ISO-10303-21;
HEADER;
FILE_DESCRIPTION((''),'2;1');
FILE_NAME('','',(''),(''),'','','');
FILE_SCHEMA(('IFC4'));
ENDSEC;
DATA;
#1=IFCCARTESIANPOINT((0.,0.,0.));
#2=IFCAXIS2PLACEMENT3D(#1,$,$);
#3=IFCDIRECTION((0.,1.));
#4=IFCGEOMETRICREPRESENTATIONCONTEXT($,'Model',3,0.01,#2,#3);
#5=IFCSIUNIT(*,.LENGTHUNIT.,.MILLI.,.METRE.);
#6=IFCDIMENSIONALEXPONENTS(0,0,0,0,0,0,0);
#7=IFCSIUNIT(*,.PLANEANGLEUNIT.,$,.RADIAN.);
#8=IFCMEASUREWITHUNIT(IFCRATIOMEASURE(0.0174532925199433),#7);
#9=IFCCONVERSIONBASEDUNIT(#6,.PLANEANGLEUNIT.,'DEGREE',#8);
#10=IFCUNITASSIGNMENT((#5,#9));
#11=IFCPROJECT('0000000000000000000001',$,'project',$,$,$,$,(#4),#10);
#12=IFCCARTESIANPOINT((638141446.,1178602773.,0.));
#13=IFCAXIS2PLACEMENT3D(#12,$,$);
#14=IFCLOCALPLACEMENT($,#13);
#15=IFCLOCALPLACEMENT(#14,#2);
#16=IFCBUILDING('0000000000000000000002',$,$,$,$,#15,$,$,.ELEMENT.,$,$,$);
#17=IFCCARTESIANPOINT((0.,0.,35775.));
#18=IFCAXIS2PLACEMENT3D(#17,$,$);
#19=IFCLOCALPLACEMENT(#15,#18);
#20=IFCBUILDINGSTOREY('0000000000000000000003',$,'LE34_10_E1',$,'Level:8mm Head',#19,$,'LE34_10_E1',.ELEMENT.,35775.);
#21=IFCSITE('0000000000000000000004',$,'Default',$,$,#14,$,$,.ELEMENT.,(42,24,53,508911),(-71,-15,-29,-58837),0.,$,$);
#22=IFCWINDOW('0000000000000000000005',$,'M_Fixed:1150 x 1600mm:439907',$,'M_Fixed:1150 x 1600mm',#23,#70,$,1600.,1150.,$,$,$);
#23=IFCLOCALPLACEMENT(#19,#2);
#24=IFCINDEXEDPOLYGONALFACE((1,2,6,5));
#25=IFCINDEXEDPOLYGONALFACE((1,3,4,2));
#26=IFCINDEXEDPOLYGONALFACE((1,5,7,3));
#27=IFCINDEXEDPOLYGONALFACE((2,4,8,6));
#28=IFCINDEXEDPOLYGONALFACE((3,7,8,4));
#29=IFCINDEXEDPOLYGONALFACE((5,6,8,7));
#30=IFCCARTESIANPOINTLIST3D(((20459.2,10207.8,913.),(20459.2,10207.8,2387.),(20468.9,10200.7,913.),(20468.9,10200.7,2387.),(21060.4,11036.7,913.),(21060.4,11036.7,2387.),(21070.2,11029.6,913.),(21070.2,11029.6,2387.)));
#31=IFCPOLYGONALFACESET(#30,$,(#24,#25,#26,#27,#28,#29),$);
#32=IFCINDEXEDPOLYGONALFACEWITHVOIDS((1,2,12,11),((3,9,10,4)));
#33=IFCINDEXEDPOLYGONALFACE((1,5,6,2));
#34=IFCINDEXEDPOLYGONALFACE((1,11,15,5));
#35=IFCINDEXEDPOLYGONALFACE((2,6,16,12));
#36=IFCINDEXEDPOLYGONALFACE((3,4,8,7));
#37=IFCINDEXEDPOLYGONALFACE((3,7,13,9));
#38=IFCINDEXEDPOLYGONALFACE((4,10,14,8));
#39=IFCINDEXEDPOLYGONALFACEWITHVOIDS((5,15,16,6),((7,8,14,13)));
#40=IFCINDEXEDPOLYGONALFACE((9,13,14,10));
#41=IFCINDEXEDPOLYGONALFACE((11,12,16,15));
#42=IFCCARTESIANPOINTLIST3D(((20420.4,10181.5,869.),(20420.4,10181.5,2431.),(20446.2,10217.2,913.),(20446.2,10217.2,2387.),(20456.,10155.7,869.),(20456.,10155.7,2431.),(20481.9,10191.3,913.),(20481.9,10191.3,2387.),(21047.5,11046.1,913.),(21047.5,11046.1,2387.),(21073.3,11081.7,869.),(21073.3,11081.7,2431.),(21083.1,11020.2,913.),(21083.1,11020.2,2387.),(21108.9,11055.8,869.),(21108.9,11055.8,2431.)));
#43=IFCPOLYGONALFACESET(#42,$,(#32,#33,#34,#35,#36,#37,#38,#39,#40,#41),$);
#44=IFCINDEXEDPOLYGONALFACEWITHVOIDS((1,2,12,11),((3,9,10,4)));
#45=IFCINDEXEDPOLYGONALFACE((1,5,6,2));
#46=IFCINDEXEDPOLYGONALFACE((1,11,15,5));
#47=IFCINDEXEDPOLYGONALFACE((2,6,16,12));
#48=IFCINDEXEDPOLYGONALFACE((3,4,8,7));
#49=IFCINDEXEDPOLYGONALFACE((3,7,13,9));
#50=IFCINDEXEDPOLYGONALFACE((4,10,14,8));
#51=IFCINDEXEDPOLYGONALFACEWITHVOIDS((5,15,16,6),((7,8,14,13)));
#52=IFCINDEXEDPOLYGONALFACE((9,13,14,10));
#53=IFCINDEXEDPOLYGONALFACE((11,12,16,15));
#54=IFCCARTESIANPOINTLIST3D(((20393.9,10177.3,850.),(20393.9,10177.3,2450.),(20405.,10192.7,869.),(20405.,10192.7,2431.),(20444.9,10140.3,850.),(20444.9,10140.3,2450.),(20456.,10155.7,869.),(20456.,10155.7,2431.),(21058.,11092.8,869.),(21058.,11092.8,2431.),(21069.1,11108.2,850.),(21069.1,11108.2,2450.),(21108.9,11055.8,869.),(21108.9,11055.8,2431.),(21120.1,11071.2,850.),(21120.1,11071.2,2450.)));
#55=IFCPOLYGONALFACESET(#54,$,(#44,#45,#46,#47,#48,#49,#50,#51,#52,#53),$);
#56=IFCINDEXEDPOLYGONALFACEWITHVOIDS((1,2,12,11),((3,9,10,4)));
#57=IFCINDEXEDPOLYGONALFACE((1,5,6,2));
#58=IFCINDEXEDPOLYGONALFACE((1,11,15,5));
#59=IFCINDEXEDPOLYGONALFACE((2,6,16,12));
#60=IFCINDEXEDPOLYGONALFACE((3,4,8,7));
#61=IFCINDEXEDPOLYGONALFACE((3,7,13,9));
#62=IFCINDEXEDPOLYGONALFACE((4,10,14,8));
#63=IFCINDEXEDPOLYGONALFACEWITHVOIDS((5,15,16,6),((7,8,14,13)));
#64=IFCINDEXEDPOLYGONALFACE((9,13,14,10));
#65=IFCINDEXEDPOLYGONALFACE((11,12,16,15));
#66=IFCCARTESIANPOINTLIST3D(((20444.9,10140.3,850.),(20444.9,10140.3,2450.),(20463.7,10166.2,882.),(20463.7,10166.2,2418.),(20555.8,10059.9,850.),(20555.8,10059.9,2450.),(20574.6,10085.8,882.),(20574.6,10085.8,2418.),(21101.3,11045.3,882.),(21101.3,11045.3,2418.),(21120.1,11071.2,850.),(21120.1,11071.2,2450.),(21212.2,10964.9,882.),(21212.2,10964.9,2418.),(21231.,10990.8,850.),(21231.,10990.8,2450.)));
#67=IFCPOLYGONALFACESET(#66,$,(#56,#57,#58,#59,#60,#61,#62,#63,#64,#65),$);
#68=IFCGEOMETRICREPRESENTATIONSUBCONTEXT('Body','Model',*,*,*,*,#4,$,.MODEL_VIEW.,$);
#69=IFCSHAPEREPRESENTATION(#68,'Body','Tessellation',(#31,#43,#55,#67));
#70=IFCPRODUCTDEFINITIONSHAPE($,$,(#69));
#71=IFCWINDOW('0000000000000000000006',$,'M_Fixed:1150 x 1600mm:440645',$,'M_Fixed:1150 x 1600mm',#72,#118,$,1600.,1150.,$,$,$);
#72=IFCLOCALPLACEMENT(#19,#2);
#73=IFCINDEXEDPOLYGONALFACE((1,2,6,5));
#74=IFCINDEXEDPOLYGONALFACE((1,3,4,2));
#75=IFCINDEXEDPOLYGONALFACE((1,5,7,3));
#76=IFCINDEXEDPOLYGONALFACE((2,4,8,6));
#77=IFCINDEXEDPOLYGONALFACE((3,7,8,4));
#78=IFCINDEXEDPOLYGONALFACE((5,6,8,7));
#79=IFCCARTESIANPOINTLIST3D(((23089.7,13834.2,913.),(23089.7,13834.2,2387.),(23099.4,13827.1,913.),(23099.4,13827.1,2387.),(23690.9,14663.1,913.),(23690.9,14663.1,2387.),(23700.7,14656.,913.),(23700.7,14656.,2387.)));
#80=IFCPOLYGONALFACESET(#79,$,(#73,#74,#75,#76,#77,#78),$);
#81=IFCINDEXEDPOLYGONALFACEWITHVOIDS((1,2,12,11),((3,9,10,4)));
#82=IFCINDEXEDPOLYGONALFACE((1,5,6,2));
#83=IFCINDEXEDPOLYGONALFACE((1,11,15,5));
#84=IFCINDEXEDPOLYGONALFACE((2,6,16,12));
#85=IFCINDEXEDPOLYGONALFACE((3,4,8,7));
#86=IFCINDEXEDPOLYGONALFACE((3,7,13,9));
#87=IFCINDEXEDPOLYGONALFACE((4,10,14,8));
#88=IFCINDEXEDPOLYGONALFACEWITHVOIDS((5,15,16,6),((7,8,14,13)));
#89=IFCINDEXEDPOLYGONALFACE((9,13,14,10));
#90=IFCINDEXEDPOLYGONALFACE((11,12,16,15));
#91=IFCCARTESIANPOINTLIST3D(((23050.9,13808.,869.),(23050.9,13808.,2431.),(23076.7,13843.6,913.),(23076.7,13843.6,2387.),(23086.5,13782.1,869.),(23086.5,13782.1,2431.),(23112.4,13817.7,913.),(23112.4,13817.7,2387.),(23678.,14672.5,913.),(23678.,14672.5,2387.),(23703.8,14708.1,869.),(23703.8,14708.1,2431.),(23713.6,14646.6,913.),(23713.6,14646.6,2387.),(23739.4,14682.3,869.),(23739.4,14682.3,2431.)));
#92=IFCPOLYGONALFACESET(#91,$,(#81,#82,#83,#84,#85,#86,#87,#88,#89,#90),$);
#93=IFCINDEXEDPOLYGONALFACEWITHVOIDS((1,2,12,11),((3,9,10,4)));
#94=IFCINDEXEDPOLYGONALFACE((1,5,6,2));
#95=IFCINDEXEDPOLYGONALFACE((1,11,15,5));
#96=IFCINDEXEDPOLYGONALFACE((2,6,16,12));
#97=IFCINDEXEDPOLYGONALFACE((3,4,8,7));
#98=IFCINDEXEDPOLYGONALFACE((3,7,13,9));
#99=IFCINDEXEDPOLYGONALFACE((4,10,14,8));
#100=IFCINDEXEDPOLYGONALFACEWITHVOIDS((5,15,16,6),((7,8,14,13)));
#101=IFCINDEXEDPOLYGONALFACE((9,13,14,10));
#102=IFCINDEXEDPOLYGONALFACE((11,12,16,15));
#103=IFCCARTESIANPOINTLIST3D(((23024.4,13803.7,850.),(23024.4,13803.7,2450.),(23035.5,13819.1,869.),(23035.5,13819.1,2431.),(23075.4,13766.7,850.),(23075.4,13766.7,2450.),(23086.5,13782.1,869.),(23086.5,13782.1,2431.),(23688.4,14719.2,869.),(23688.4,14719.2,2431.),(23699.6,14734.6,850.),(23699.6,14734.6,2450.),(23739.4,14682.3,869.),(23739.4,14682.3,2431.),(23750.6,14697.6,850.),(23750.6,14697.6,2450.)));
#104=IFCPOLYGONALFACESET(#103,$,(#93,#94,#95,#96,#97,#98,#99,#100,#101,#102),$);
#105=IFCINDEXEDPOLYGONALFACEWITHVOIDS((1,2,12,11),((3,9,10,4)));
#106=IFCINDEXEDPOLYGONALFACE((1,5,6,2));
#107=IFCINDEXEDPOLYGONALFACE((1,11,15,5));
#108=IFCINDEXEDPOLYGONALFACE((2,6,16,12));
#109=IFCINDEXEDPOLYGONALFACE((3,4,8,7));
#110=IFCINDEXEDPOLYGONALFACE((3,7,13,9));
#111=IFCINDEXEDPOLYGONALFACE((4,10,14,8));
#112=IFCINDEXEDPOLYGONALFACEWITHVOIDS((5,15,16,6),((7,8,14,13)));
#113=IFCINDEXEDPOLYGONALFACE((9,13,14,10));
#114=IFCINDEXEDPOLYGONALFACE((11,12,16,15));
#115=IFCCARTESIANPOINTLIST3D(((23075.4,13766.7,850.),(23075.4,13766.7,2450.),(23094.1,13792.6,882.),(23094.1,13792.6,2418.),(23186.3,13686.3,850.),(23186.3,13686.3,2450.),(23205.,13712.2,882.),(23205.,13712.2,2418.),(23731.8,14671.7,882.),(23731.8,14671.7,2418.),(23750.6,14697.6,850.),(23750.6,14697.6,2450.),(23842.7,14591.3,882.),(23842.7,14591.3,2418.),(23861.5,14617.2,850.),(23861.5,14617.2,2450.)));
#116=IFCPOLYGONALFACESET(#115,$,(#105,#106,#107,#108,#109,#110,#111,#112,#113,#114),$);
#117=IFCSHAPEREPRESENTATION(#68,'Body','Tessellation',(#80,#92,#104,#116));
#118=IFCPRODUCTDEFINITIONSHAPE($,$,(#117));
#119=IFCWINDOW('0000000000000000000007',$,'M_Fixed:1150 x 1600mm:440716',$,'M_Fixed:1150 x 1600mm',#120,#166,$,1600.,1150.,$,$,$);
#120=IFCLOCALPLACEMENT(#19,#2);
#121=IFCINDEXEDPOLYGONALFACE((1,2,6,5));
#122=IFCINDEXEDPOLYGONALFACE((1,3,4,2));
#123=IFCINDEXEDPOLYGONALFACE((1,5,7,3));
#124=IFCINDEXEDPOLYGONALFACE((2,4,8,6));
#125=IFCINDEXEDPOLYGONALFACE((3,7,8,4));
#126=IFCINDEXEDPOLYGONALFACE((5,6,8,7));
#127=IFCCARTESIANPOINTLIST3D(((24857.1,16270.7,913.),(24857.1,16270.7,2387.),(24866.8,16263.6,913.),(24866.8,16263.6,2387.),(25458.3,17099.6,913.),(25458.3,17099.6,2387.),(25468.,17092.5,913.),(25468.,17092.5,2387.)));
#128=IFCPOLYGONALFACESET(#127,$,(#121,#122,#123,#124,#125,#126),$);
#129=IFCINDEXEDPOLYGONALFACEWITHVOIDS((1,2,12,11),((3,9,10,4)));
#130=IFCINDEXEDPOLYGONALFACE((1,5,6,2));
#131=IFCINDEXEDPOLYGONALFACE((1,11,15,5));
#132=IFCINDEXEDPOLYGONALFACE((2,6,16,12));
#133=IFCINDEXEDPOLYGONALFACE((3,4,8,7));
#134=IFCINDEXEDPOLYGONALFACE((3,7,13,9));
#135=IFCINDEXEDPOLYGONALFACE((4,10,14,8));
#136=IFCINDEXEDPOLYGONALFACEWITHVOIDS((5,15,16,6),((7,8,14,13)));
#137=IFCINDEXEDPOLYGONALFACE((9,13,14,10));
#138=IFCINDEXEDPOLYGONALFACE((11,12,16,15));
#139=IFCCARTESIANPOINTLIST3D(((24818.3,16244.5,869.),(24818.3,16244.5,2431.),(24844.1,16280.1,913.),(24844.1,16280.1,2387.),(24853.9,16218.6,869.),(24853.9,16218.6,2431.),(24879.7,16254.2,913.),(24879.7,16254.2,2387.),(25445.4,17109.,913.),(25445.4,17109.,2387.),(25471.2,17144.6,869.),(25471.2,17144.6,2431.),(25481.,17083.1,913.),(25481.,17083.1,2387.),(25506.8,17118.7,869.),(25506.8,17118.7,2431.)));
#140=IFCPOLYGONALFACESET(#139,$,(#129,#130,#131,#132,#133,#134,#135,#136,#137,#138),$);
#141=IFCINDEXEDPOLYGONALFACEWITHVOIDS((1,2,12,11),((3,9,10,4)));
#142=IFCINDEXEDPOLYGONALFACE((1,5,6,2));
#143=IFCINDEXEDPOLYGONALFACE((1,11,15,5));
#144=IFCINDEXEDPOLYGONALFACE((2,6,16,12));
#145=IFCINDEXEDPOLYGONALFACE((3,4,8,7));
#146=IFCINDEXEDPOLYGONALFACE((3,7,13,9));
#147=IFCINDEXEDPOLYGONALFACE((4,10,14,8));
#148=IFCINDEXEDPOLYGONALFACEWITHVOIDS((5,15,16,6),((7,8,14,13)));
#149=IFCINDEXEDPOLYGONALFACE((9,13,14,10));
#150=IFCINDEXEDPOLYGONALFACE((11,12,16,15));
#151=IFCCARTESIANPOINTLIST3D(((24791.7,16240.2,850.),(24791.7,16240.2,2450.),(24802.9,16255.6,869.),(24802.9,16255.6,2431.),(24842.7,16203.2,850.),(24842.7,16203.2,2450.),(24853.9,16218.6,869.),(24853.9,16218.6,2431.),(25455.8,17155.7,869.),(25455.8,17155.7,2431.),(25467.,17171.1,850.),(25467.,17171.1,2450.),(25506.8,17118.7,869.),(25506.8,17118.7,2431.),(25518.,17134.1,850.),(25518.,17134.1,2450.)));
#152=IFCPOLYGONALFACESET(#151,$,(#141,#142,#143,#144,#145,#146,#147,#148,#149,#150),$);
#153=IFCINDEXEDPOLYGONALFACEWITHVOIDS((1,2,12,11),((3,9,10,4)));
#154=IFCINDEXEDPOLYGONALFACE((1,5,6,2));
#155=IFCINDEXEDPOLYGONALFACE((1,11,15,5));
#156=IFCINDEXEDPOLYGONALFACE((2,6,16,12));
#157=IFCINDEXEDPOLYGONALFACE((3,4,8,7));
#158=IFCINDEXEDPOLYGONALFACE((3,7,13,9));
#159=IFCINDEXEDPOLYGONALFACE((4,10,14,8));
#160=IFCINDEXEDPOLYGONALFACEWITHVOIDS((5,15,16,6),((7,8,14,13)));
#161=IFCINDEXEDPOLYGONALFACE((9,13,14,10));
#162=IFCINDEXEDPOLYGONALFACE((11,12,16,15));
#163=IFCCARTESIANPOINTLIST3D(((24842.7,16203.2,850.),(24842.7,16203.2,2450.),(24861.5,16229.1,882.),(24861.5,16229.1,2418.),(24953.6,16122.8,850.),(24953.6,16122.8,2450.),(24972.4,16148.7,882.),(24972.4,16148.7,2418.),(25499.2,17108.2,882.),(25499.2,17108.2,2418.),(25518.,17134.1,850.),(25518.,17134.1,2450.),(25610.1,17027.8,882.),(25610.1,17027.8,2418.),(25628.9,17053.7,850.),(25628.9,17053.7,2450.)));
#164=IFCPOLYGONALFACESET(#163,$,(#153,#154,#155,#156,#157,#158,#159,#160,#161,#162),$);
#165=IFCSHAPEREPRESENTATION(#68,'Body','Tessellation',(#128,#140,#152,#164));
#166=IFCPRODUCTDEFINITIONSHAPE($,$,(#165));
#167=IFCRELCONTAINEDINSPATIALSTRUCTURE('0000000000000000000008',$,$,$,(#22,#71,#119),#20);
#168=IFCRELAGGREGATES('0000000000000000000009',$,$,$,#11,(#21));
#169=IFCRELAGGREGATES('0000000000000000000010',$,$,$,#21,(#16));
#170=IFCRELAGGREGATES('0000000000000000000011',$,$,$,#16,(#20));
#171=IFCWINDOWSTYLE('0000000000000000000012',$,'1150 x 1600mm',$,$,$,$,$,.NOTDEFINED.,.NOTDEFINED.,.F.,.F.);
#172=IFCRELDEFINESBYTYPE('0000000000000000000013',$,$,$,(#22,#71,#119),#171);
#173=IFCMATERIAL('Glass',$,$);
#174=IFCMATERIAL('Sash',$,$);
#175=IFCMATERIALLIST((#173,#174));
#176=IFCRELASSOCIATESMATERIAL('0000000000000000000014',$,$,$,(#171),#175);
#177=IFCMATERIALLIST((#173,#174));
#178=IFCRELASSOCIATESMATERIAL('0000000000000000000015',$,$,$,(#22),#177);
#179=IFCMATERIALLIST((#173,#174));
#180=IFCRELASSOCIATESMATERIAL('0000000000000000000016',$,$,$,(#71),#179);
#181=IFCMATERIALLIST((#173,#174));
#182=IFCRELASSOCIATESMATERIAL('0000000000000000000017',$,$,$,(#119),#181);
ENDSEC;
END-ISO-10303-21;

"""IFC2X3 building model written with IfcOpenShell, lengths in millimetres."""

from ifc_helpers import new_model, entity, si_unit, converted_unit, direction, frame, frame_2d, origin, place, context, subcontext, project, spatial, polyline, rectangle, outline, extrude, source, transform, mapped, material, material_list, type_object, type_shapes, element, save


model = new_model("IFC2X3")

# Units and contexts
model_context = context("Model", 3, precision=0.01, world=origin(), true_north=direction((0.0, 1.0)))
body_context = subcontext(model_context, "Body", "Model", "MODEL_VIEW")
ifc_project = project(units=[si_unit("LENGTHUNIT", "METRE", prefix="MILLI"), converted_unit("PLANEANGLEUNIT", "DEGREE", entity("IfcRatioMeasure", 0.0174532925199433), si_unit("PLANEANGLEUNIT", "RADIAN"), dimensions=[0, 0, 0, 0, 0, 0, 0])], contexts=[model_context])

# Site, building, storey
site_placement = place(None, frame((638141446.0, 1178602773.0, 0.0)))
site = spatial("IfcSite", under=ifc_project, at=site_placement, Name="Default", CompositionType="ELEMENT", RefLatitude=(42, 24, 53, 508911), RefLongitude=(-71, -15, -29, -58837), RefElevation=0.0)
building_placement = place(site_placement, origin())
building = spatial("IfcBuilding", under=site, at=building_placement, CompositionType="ELEMENT")
storey_placement = place(building_placement, frame((0.0, 0.0, 35775.0)))
storey = spatial("IfcBuildingStorey", under=building, at=storey_placement, Name="LE34_10_E1", ObjectType="Level:8mm Head", LongName="LE34_10_E1", CompositionType="ELEMENT", Elevation=35775.0)

# Windows
ifc_material_1 = material(Name="Glass")
ifc_material_2 = material(Name="Sash")
ifc_material_list_1 = material_list([ifc_material_1, ifc_material_2])
ifc_material_list_2 = material_list([ifc_material_1, ifc_material_2])
window_style_1 = type_object("IfcWindowStyle", Name="1150 x 1600mm", ConstructionType="NOTDEFINED", OperationType="NOTDEFINED", ParameterTakesPrecedence=False, Sizeable=False, material=ifc_material_list_2)
shared_shape_1 = source(origin(), body_context, "Body", "SweptSolid", [
    extrude(rectangle(XDim=12.0, YDim=1024.0, at=frame_2d((0.0, 0.0), x_axis=(1.0, 0.0))), frame((575.0, 269.0, 63.0), z_axis=(0.0, 0.0, 1.0), x_axis=(0.0, -1.0, 0.0)), (0.0, 0.0, 1.0), 1474.0),
    extrude(outline(polyline([(-556.0, -781.0), (556.0, -781.0), (556.0, 781.0), (-556.0, 781.0), (-556.0, -781.0)]), holes=[polyline([(-512.0, -737.0), (-512.0, 737.0), (512.0, 737.0), (512.0, -737.0), (-512.0, -737.0)])]), frame((575.0, 247.0, 800.0), z_axis=(0.0, 1.0, 0.0), x_axis=(1.0, 0.0, 0.0)), (0.0, 0.0, 1.0), 44.0),
    extrude(outline(polyline([(-575.0, -800.0), (575.0, -800.0), (575.0, 800.0), (-575.0, 800.0), (-575.0, -800.0)]), holes=[polyline([(-556.0, -781.0), (-556.0, 781.0), (556.0, 781.0), (556.0, -781.0), (-556.0, -781.0)])]), frame((575.0, 247.0, 800.0), z_axis=(0.0, 1.0, 0.0), x_axis=(1.0, 0.0, 0.0)), (0.0, 0.0, 1.0), 63.0),
    extrude(outline(polyline([(-575.0, -800.0), (575.0, -800.0), (575.0, 800.0), (-575.0, 800.0), (-575.0, -800.0)]), holes=[polyline([(-543.0, -768.0), (-543.0, 768.0), (543.0, 768.0), (543.0, -768.0), (-543.0, -768.0)])]), frame((575.0, 110.0, 800.0), z_axis=(0.0, 1.0, 0.0), x_axis=(1.0, 0.0, 0.0)), (0.0, 0.0, 1.0), 137.0),
])
type_shapes(window_style_1, [shared_shape_1])
window_1_placement = place(storey_placement, frame((20644.8, 9995.3, 850.0), z_axis=(0.0, 0.0, 1.0), x_axis=(0.587164, 0.809468, 0.0)))
element("IfcWindow", 1, at=window_1_placement, inside=storey, type_object=window_style_1, material=ifc_material_list_1, Name="M_Fixed:1150 x 1600mm:439907", ObjectType="M_Fixed:1150 x 1600mm", OverallHeight=1600.0, OverallWidth=1150.0, context=body_context, shape_type="MappedRepresentation", body=[
    mapped(shared_shape_1, transform((0.0, 0.0, 0.0), scale=1.0)),
])
ifc_material_list_3 = material_list([ifc_material_1, ifc_material_2])
window_2_placement = place(storey_placement, frame((23275.3, 13621.7, 850.0), z_axis=(0.0, 0.0, 1.0), x_axis=(0.587164, 0.809468, 0.0)))
element("IfcWindow", 2, at=window_2_placement, inside=storey, type_object=window_style_1, material=ifc_material_list_3, Name="M_Fixed:1150 x 1600mm:440645", ObjectType="M_Fixed:1150 x 1600mm", OverallHeight=1600.0, OverallWidth=1150.0, context=body_context, shape_type="MappedRepresentation", body=[
    mapped(shared_shape_1, transform((0.0, 0.0, 0.0), scale=1.0)),
])
ifc_material_list_4 = material_list([ifc_material_1, ifc_material_2])
window_3_placement = place(storey_placement, frame((25042.7, 16058.2, 850.0), z_axis=(0.0, 0.0, 1.0), x_axis=(0.587164, 0.809468, 0.0)))
element("IfcWindow", 3, at=window_3_placement, inside=storey, type_object=window_style_1, material=ifc_material_list_4, Name="M_Fixed:1150 x 1600mm:440716", ObjectType="M_Fixed:1150 x 1600mm", OverallHeight=1600.0, OverallWidth=1150.0, context=body_context, shape_type="MappedRepresentation", body=[
    mapped(shared_shape_1, transform((0.0, 0.0, 0.0), scale=1.0)),
])

save(model, "model.ifc")
